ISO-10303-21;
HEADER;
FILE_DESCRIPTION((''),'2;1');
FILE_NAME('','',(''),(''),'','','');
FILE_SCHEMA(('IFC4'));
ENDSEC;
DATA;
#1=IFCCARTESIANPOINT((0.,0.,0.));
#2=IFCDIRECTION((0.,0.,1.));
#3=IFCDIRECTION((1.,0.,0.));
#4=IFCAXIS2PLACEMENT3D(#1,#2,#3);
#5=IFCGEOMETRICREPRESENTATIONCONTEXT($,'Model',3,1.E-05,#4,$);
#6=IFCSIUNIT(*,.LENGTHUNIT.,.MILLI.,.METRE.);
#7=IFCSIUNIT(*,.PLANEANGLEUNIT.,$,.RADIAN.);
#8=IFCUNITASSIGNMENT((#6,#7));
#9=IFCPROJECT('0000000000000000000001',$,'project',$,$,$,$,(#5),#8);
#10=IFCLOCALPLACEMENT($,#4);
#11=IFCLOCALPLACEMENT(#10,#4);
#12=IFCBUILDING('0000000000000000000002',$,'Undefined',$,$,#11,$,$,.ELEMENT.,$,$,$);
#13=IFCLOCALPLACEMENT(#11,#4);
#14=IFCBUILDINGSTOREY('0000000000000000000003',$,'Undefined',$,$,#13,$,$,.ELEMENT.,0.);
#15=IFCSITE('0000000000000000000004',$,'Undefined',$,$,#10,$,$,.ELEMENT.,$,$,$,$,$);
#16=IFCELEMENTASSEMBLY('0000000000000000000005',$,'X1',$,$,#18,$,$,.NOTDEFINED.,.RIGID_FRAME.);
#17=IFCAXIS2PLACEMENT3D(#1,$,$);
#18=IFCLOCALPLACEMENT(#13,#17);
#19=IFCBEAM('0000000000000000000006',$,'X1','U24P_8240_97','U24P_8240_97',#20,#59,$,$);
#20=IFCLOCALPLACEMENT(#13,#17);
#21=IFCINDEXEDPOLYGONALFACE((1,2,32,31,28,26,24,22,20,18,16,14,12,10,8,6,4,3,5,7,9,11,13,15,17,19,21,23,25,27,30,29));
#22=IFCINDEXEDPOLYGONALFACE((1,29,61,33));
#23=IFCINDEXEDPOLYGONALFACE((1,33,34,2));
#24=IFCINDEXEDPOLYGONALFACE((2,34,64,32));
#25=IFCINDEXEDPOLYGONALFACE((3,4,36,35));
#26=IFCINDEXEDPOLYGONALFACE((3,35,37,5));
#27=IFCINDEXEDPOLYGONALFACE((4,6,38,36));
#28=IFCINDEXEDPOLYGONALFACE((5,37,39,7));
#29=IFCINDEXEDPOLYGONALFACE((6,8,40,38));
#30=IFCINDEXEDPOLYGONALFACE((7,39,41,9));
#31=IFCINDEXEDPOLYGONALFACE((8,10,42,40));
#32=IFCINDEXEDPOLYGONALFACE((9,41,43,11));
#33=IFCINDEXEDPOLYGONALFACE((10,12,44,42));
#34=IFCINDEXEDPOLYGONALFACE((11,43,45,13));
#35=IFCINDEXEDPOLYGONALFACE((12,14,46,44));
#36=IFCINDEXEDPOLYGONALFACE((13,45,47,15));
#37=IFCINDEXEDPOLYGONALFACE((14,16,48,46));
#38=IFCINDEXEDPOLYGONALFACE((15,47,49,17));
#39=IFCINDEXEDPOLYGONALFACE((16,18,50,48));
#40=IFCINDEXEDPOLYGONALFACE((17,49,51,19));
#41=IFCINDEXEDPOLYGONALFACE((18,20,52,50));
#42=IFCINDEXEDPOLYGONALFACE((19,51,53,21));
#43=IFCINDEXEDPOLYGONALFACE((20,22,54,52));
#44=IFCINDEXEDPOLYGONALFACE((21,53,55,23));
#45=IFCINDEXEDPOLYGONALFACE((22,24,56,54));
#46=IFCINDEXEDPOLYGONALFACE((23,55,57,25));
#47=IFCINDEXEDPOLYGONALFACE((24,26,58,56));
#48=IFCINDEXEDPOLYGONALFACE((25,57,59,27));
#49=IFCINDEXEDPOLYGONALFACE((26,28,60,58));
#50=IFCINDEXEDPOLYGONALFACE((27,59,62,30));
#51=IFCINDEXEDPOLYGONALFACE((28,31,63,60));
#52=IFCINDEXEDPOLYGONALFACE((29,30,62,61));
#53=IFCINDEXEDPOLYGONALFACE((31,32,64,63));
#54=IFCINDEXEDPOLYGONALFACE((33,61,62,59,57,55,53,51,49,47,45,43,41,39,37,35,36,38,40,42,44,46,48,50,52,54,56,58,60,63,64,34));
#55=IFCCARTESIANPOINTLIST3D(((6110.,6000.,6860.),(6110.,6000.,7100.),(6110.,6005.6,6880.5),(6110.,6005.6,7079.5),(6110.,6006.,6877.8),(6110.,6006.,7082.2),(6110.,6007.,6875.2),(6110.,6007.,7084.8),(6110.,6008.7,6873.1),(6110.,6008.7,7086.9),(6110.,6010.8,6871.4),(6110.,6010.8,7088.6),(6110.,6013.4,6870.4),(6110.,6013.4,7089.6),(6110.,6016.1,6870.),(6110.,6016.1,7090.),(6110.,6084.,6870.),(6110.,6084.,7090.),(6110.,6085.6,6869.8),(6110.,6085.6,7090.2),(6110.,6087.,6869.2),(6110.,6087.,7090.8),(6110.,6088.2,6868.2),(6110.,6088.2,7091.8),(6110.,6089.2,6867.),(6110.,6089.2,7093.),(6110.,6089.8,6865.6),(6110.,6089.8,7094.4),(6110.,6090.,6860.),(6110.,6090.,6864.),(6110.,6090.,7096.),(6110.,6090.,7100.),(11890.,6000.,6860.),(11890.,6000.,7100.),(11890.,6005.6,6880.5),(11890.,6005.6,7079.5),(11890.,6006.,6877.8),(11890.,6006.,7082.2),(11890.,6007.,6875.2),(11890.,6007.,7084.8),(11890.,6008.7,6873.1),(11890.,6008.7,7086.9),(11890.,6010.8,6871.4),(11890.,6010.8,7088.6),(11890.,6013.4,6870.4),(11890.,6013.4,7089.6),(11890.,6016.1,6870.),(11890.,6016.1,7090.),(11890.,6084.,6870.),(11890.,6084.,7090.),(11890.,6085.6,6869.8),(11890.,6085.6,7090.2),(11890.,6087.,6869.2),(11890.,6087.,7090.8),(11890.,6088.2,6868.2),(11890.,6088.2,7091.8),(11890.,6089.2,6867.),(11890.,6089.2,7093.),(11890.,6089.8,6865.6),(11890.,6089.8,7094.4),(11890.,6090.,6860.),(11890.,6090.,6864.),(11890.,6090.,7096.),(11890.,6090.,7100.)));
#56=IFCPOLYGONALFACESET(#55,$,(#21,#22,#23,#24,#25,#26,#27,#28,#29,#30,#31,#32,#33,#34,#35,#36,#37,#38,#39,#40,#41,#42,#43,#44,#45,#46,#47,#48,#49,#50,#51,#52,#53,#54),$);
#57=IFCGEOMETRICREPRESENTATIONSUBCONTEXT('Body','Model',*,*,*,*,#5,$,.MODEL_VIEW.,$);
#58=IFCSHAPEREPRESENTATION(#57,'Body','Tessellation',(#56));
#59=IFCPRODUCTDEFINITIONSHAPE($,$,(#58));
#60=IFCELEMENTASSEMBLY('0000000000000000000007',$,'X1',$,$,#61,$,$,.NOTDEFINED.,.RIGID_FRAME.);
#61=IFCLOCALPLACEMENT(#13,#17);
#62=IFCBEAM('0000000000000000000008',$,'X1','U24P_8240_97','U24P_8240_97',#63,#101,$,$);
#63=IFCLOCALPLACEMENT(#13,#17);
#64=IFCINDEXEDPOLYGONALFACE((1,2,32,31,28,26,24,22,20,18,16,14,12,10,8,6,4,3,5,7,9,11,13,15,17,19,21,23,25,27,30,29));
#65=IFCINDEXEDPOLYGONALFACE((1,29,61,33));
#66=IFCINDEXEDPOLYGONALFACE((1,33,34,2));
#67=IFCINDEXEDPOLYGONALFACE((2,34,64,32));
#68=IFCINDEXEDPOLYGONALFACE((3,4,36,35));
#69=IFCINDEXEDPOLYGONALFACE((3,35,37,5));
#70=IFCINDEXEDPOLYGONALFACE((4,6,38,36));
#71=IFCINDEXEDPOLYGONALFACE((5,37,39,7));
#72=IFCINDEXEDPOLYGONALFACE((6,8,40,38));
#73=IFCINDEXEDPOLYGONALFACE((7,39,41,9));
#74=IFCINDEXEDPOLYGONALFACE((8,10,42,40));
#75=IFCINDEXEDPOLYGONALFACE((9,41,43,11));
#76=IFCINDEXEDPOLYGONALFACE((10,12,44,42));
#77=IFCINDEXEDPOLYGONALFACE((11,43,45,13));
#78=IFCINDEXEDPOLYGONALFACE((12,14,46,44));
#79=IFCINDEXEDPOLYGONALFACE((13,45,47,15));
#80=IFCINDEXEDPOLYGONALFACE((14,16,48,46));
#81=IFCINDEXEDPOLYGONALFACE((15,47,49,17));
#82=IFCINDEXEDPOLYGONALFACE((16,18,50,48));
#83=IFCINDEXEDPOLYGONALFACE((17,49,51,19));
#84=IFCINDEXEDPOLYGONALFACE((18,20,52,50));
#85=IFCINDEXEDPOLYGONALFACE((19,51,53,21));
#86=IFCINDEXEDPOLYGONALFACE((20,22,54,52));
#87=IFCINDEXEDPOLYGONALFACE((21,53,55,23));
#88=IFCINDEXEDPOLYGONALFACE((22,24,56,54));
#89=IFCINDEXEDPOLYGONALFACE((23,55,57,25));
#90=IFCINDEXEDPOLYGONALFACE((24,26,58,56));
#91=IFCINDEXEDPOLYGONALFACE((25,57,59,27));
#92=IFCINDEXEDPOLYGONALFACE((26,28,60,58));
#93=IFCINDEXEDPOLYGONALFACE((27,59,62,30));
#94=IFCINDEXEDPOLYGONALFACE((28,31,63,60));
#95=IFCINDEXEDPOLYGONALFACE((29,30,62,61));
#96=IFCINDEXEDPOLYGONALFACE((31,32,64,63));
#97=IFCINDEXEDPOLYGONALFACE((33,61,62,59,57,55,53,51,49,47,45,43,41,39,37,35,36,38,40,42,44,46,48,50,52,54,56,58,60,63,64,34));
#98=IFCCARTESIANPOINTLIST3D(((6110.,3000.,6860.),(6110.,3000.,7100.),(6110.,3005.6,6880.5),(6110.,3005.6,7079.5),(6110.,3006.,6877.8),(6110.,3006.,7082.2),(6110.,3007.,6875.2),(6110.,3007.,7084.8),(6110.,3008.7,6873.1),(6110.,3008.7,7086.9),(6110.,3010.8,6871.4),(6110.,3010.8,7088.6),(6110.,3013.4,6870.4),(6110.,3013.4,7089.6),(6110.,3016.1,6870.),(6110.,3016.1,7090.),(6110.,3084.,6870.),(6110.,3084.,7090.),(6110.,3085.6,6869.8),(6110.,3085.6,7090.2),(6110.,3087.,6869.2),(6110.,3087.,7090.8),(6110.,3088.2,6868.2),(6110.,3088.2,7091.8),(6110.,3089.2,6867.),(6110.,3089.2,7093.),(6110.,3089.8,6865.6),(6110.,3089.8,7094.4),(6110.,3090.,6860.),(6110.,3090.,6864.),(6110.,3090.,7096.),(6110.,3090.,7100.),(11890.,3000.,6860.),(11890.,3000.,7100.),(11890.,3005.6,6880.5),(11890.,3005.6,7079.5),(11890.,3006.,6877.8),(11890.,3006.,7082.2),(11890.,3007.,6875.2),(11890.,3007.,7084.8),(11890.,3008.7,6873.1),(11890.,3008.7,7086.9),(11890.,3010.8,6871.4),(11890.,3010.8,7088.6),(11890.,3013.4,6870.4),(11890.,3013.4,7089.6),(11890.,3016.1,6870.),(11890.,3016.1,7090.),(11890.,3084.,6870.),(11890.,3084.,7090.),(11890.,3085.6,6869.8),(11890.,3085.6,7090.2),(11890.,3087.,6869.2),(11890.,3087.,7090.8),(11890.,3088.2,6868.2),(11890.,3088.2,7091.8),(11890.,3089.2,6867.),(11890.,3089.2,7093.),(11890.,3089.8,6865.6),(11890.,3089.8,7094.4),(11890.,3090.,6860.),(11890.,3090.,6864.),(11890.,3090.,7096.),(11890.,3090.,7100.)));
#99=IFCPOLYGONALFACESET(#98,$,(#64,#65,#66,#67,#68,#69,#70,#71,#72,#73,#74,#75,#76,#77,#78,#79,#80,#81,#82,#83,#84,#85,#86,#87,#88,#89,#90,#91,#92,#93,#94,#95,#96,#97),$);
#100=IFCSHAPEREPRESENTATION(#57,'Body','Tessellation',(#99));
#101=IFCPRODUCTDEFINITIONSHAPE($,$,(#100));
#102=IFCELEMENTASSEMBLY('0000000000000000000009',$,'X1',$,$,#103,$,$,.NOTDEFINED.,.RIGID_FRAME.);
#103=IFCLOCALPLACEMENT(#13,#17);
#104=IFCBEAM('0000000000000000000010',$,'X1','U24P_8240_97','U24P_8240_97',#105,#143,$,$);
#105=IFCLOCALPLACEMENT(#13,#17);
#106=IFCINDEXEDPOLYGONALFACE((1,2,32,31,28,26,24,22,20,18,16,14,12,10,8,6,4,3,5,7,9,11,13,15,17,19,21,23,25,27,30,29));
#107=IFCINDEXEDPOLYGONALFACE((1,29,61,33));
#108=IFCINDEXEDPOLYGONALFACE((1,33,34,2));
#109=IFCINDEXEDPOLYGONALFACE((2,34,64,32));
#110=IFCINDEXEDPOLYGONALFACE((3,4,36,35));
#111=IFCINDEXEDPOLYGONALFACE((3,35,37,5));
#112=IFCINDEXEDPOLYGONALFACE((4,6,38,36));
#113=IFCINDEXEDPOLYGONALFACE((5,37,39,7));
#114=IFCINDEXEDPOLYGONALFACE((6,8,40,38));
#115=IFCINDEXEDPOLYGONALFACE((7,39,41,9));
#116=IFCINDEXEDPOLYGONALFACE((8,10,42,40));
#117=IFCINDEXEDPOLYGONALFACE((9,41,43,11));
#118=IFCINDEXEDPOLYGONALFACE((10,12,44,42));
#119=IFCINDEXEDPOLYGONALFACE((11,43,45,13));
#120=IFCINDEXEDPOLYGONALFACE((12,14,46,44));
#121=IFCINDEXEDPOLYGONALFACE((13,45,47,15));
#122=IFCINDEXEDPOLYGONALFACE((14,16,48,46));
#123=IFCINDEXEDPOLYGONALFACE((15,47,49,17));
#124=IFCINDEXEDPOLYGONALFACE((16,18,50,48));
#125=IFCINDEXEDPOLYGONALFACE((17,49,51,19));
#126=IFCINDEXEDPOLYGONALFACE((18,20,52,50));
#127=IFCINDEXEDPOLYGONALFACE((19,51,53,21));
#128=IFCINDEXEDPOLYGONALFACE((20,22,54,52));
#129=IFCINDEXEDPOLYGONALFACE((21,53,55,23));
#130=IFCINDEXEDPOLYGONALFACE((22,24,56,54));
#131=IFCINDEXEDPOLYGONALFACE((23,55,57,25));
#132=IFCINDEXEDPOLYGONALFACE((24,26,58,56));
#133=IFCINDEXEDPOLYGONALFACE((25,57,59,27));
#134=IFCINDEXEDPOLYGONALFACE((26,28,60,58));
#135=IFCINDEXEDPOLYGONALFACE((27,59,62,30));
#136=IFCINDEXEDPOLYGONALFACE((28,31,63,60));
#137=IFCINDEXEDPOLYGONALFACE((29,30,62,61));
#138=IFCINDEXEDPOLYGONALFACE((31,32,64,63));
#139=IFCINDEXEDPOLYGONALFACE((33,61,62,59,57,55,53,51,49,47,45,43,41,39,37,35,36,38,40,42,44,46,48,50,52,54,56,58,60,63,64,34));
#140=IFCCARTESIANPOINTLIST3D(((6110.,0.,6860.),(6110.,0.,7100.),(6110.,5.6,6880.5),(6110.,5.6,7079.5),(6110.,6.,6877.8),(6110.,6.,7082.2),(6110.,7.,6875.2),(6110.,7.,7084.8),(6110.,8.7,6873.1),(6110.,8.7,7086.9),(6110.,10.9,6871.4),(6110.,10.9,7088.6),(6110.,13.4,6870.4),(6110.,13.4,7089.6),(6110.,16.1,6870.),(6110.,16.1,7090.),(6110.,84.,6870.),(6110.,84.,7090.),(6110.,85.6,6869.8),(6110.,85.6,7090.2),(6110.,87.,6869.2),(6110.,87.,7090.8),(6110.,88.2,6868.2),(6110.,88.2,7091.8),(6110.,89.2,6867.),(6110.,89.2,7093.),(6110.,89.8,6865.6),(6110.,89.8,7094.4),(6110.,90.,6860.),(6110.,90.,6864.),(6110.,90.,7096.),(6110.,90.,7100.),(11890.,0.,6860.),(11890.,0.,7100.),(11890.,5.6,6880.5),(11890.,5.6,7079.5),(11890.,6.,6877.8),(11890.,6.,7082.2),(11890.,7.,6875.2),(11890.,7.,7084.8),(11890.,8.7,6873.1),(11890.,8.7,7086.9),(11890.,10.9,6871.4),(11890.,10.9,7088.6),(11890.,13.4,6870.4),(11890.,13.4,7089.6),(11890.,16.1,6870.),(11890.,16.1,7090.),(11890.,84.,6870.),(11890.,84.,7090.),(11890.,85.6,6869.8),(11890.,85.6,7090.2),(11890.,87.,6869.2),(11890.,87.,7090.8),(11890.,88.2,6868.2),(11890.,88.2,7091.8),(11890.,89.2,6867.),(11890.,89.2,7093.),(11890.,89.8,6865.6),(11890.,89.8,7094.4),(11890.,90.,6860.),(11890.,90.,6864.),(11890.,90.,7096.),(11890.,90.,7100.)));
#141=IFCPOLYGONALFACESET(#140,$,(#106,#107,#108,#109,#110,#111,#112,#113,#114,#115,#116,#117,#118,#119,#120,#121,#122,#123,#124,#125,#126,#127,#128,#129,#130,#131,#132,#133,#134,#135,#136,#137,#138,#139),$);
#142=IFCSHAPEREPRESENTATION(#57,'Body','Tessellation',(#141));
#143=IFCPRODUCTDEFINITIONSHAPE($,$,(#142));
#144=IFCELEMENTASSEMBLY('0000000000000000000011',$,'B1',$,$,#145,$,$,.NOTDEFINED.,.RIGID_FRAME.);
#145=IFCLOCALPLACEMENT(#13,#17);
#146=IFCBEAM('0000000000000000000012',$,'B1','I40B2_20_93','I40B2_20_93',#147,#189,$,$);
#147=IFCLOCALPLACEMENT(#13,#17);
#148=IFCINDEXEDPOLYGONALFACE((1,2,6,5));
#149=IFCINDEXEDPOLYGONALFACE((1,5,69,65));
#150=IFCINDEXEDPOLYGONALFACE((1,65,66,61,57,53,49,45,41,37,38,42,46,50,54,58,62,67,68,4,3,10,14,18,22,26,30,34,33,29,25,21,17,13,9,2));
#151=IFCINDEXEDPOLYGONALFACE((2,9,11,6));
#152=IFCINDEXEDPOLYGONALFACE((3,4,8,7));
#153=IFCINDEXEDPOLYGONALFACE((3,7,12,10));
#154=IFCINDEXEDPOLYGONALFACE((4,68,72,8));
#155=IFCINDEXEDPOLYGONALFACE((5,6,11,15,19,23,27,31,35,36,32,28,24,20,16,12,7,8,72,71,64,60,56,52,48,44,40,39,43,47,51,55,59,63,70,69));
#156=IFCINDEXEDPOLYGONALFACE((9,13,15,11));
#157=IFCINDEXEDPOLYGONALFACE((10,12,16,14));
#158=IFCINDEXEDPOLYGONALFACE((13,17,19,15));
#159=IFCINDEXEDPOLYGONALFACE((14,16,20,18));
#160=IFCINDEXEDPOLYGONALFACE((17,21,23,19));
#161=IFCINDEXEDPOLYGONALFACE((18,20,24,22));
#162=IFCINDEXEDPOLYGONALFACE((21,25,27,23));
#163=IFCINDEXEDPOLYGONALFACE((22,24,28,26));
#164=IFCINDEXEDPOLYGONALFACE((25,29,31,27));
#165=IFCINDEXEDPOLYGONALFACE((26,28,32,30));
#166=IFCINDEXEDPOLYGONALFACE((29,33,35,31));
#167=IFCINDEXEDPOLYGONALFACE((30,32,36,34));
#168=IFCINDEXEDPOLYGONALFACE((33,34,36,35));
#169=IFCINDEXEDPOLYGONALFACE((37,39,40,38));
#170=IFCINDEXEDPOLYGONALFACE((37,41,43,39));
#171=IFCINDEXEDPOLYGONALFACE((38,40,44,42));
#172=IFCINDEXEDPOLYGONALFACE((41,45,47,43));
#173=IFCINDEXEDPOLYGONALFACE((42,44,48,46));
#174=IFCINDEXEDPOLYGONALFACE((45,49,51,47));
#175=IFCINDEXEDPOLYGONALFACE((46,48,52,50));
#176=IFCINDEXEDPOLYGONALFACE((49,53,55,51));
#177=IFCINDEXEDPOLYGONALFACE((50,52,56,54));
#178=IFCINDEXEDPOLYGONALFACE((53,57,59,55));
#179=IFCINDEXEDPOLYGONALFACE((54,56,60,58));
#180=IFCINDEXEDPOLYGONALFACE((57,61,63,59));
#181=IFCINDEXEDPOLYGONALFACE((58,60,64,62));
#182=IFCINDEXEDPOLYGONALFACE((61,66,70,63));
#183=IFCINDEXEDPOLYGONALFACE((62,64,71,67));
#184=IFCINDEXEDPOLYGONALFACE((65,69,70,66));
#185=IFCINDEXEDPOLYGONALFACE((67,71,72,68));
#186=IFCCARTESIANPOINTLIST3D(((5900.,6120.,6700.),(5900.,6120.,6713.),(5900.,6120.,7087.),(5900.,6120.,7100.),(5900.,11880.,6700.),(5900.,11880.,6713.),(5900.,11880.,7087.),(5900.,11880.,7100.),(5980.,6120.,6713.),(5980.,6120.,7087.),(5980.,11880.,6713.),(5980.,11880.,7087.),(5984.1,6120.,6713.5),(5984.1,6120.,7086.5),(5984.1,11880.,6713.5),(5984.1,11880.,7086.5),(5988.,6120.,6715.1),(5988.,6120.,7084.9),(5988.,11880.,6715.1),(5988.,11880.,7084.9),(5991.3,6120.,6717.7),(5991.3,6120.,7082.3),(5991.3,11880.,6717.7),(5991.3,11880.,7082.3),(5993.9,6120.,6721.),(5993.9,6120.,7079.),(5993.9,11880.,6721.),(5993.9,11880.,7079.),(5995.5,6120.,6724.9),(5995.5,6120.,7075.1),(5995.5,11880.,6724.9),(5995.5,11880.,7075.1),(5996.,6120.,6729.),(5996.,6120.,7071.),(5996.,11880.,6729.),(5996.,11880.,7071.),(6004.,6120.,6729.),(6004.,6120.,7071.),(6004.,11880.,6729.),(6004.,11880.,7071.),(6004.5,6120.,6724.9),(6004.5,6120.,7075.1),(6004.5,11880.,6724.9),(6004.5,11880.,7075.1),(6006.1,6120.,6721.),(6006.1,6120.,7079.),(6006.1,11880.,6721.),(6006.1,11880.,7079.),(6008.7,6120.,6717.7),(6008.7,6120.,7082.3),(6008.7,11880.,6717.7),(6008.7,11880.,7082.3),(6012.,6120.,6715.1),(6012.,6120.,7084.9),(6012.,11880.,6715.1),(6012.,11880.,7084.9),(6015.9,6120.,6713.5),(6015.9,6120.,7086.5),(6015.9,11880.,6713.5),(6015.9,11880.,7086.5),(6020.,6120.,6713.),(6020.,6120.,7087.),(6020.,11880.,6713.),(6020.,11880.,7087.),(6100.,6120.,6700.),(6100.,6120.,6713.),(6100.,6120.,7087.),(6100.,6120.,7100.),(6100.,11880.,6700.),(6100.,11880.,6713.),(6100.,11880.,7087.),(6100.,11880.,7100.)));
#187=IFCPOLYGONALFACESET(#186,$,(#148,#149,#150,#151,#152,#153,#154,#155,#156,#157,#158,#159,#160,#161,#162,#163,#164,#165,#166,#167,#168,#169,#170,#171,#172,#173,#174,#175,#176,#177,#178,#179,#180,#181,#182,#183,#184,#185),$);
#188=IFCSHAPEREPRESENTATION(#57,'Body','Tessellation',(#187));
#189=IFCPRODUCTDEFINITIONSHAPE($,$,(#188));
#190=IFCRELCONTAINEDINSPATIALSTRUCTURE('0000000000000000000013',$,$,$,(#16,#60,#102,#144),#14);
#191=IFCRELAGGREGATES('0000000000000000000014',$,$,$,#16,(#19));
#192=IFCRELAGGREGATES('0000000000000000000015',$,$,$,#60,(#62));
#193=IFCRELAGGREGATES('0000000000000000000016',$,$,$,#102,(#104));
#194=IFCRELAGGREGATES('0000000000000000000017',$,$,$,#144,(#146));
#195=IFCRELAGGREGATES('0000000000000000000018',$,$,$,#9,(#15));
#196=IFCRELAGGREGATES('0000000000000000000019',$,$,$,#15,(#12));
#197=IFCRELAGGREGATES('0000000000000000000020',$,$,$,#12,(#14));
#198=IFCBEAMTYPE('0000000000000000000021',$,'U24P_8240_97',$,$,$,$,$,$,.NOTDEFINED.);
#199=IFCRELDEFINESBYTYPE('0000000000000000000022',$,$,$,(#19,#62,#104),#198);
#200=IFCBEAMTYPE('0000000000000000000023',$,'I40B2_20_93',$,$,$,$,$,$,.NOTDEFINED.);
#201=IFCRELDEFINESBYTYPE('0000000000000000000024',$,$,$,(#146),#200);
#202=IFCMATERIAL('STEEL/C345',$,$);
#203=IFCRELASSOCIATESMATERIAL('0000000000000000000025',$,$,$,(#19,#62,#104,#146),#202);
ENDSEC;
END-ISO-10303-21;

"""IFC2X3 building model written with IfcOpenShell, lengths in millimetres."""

from ifc_helpers import new_model, si_unit, frame, origin_with_axes, origin_2d_with_axis, place, context, subcontext, project, spatial, i_section, u_section, extrude, material, type_object, element, aggregate, save


model = new_model("IFC2X3")

# Units and contexts
model_context = context("Model", 3, precision=1e-05, world=origin_with_axes())
body_context = subcontext(model_context, "Body", "Model", "MODEL_VIEW")
ifc_project = project(units=[si_unit("LENGTHUNIT", "METRE", prefix="MILLI"), si_unit("PLANEANGLEUNIT", "RADIAN")], contexts=[model_context])

# Site, building, storey
site_placement = place(None, origin_with_axes())
site = spatial("IfcSite", under=ifc_project, at=site_placement, Name="Undefined", CompositionType="ELEMENT")
building_placement = place(site_placement, origin_with_axes())
building = spatial("IfcBuilding", under=site, at=building_placement, Name="Undefined", CompositionType="ELEMENT")
storey_placement = place(building_placement, origin_with_axes())
storey = spatial("IfcBuildingStorey", under=building, at=storey_placement, Name="Undefined", CompositionType="ELEMENT", Elevation=0.0)

# Element assemblies, beams
assembly_1_placement = place(storey_placement, origin_with_axes())
assembly_1 = element("IfcElementAssembly", 1, at=assembly_1_placement, inside=storey, Name="X1", AssemblyPlace="NOTDEFINED", PredefinedType="RIGID_FRAME")
ifc_material_1 = material(Name="STEEL/C345")
beam_type_1 = type_object("IfcBeamType", Name="U24P_8240_97", PredefinedType="NOTDEFINED")
beam_1_placement = place(assembly_1_placement, frame((6110.0, 6045.0, 6980.0), z_axis=(0.0, 0.0, -1.0), x_axis=(1.0, 0.0, 0.0)))
beam_1 = element("IfcBeam", 2, at=beam_1_placement, type_object=beam_type_1, material=ifc_material_1, Name="X1", Description="U24P_8240_97", ObjectType="U24P_8240_97", context=body_context, shape_type="SweptSolid", body=[
    extrude(u_section(Depth=240.0, FlangeWidth=90.0, WebThickness=5.6, FlangeThickness=10.0, FilletRadius=10.5, EdgeRadius=6.0, at=origin_2d_with_axis()), frame((5780.0, 0.0, 0.0), z_axis=(-1.0, 0.0, 0.0), x_axis=(0.0, -1.0, 0.0)), (0.0, 0.0, 1.0), 5780.0),
])
aggregate(assembly_1, [beam_1])
assembly_2_placement = place(storey_placement, origin_with_axes())
assembly_2 = element("IfcElementAssembly", 3, at=assembly_2_placement, inside=storey, Name="X1", AssemblyPlace="NOTDEFINED", PredefinedType="RIGID_FRAME")
beam_2_placement = place(assembly_2_placement, frame((6110.0, 3045.0, 6980.0), z_axis=(0.0, 0.0, -1.0), x_axis=(1.0, 0.0, 0.0)))
beam_2 = element("IfcBeam", 4, at=beam_2_placement, type_object=beam_type_1, material=ifc_material_1, Name="X1", Description="U24P_8240_97", ObjectType="U24P_8240_97", context=body_context, shape_type="SweptSolid", body=[
    extrude(u_section(Depth=240.0, FlangeWidth=90.0, WebThickness=5.6, FlangeThickness=10.0, FilletRadius=10.5, EdgeRadius=6.0, at=origin_2d_with_axis()), frame((5780.0, 0.0, 0.0), z_axis=(-1.0, 0.0, 0.0), x_axis=(0.0, -1.0, 0.0)), (0.0, 0.0, 1.0), 5780.0),
])
aggregate(assembly_2, [beam_2])
assembly_3_placement = place(storey_placement, origin_with_axes())
assembly_3 = element("IfcElementAssembly", 5, at=assembly_3_placement, inside=storey, Name="X1", AssemblyPlace="NOTDEFINED", PredefinedType="RIGID_FRAME")
beam_3_placement = place(assembly_3_placement, frame((6110.0, 45.0, 6980.0), z_axis=(0.0, 0.0, -1.0), x_axis=(1.0, 0.0, 0.0)))
beam_3 = element("IfcBeam", 6, at=beam_3_placement, type_object=beam_type_1, material=ifc_material_1, Name="X1", Description="U24P_8240_97", ObjectType="U24P_8240_97", context=body_context, shape_type="SweptSolid", body=[
    extrude(u_section(Depth=240.0, FlangeWidth=90.0, WebThickness=5.6, FlangeThickness=10.0, FilletRadius=10.5, EdgeRadius=6.0, at=origin_2d_with_axis()), frame((5780.0, 0.0, 0.0), z_axis=(-1.0, 0.0, 0.0), x_axis=(0.0, -1.0, 0.0)), (0.0, 0.0, 1.0), 5780.0),
])
aggregate(assembly_3, [beam_3])
assembly_4_placement = place(storey_placement, origin_with_axes())
assembly_4 = element("IfcElementAssembly", 7, at=assembly_4_placement, inside=storey, Name="B1", AssemblyPlace="NOTDEFINED", PredefinedType="RIGID_FRAME")
beam_type_2 = type_object("IfcBeamType", Name="I40B2_20_93", PredefinedType="NOTDEFINED")
beam_4_placement = place(assembly_4_placement, frame((6000.0, 6120.0, 6900.0), z_axis=(0.0, 0.0, 1.0), x_axis=(0.0, 1.0, 0.0)))
beam_4 = element("IfcBeam", 8, at=beam_4_placement, type_object=beam_type_2, material=ifc_material_1, Name="B1", Description="I40B2_20_93", ObjectType="I40B2_20_93", context=body_context, shape_type="SweptSolid", body=[
    extrude(i_section(OverallWidth=200.0, OverallDepth=400.0, WebThickness=8.0, FlangeThickness=13.0, FilletRadius=16.0, at=origin_2d_with_axis()), frame((5760.0, 0.0, 0.0), z_axis=(-1.0, 0.0, 0.0), x_axis=(0.0, -1.0, 0.0)), (0.0, 0.0, 1.0), 5760.0),
])
aggregate(assembly_4, [beam_4])

save(model, "model.ifc")
